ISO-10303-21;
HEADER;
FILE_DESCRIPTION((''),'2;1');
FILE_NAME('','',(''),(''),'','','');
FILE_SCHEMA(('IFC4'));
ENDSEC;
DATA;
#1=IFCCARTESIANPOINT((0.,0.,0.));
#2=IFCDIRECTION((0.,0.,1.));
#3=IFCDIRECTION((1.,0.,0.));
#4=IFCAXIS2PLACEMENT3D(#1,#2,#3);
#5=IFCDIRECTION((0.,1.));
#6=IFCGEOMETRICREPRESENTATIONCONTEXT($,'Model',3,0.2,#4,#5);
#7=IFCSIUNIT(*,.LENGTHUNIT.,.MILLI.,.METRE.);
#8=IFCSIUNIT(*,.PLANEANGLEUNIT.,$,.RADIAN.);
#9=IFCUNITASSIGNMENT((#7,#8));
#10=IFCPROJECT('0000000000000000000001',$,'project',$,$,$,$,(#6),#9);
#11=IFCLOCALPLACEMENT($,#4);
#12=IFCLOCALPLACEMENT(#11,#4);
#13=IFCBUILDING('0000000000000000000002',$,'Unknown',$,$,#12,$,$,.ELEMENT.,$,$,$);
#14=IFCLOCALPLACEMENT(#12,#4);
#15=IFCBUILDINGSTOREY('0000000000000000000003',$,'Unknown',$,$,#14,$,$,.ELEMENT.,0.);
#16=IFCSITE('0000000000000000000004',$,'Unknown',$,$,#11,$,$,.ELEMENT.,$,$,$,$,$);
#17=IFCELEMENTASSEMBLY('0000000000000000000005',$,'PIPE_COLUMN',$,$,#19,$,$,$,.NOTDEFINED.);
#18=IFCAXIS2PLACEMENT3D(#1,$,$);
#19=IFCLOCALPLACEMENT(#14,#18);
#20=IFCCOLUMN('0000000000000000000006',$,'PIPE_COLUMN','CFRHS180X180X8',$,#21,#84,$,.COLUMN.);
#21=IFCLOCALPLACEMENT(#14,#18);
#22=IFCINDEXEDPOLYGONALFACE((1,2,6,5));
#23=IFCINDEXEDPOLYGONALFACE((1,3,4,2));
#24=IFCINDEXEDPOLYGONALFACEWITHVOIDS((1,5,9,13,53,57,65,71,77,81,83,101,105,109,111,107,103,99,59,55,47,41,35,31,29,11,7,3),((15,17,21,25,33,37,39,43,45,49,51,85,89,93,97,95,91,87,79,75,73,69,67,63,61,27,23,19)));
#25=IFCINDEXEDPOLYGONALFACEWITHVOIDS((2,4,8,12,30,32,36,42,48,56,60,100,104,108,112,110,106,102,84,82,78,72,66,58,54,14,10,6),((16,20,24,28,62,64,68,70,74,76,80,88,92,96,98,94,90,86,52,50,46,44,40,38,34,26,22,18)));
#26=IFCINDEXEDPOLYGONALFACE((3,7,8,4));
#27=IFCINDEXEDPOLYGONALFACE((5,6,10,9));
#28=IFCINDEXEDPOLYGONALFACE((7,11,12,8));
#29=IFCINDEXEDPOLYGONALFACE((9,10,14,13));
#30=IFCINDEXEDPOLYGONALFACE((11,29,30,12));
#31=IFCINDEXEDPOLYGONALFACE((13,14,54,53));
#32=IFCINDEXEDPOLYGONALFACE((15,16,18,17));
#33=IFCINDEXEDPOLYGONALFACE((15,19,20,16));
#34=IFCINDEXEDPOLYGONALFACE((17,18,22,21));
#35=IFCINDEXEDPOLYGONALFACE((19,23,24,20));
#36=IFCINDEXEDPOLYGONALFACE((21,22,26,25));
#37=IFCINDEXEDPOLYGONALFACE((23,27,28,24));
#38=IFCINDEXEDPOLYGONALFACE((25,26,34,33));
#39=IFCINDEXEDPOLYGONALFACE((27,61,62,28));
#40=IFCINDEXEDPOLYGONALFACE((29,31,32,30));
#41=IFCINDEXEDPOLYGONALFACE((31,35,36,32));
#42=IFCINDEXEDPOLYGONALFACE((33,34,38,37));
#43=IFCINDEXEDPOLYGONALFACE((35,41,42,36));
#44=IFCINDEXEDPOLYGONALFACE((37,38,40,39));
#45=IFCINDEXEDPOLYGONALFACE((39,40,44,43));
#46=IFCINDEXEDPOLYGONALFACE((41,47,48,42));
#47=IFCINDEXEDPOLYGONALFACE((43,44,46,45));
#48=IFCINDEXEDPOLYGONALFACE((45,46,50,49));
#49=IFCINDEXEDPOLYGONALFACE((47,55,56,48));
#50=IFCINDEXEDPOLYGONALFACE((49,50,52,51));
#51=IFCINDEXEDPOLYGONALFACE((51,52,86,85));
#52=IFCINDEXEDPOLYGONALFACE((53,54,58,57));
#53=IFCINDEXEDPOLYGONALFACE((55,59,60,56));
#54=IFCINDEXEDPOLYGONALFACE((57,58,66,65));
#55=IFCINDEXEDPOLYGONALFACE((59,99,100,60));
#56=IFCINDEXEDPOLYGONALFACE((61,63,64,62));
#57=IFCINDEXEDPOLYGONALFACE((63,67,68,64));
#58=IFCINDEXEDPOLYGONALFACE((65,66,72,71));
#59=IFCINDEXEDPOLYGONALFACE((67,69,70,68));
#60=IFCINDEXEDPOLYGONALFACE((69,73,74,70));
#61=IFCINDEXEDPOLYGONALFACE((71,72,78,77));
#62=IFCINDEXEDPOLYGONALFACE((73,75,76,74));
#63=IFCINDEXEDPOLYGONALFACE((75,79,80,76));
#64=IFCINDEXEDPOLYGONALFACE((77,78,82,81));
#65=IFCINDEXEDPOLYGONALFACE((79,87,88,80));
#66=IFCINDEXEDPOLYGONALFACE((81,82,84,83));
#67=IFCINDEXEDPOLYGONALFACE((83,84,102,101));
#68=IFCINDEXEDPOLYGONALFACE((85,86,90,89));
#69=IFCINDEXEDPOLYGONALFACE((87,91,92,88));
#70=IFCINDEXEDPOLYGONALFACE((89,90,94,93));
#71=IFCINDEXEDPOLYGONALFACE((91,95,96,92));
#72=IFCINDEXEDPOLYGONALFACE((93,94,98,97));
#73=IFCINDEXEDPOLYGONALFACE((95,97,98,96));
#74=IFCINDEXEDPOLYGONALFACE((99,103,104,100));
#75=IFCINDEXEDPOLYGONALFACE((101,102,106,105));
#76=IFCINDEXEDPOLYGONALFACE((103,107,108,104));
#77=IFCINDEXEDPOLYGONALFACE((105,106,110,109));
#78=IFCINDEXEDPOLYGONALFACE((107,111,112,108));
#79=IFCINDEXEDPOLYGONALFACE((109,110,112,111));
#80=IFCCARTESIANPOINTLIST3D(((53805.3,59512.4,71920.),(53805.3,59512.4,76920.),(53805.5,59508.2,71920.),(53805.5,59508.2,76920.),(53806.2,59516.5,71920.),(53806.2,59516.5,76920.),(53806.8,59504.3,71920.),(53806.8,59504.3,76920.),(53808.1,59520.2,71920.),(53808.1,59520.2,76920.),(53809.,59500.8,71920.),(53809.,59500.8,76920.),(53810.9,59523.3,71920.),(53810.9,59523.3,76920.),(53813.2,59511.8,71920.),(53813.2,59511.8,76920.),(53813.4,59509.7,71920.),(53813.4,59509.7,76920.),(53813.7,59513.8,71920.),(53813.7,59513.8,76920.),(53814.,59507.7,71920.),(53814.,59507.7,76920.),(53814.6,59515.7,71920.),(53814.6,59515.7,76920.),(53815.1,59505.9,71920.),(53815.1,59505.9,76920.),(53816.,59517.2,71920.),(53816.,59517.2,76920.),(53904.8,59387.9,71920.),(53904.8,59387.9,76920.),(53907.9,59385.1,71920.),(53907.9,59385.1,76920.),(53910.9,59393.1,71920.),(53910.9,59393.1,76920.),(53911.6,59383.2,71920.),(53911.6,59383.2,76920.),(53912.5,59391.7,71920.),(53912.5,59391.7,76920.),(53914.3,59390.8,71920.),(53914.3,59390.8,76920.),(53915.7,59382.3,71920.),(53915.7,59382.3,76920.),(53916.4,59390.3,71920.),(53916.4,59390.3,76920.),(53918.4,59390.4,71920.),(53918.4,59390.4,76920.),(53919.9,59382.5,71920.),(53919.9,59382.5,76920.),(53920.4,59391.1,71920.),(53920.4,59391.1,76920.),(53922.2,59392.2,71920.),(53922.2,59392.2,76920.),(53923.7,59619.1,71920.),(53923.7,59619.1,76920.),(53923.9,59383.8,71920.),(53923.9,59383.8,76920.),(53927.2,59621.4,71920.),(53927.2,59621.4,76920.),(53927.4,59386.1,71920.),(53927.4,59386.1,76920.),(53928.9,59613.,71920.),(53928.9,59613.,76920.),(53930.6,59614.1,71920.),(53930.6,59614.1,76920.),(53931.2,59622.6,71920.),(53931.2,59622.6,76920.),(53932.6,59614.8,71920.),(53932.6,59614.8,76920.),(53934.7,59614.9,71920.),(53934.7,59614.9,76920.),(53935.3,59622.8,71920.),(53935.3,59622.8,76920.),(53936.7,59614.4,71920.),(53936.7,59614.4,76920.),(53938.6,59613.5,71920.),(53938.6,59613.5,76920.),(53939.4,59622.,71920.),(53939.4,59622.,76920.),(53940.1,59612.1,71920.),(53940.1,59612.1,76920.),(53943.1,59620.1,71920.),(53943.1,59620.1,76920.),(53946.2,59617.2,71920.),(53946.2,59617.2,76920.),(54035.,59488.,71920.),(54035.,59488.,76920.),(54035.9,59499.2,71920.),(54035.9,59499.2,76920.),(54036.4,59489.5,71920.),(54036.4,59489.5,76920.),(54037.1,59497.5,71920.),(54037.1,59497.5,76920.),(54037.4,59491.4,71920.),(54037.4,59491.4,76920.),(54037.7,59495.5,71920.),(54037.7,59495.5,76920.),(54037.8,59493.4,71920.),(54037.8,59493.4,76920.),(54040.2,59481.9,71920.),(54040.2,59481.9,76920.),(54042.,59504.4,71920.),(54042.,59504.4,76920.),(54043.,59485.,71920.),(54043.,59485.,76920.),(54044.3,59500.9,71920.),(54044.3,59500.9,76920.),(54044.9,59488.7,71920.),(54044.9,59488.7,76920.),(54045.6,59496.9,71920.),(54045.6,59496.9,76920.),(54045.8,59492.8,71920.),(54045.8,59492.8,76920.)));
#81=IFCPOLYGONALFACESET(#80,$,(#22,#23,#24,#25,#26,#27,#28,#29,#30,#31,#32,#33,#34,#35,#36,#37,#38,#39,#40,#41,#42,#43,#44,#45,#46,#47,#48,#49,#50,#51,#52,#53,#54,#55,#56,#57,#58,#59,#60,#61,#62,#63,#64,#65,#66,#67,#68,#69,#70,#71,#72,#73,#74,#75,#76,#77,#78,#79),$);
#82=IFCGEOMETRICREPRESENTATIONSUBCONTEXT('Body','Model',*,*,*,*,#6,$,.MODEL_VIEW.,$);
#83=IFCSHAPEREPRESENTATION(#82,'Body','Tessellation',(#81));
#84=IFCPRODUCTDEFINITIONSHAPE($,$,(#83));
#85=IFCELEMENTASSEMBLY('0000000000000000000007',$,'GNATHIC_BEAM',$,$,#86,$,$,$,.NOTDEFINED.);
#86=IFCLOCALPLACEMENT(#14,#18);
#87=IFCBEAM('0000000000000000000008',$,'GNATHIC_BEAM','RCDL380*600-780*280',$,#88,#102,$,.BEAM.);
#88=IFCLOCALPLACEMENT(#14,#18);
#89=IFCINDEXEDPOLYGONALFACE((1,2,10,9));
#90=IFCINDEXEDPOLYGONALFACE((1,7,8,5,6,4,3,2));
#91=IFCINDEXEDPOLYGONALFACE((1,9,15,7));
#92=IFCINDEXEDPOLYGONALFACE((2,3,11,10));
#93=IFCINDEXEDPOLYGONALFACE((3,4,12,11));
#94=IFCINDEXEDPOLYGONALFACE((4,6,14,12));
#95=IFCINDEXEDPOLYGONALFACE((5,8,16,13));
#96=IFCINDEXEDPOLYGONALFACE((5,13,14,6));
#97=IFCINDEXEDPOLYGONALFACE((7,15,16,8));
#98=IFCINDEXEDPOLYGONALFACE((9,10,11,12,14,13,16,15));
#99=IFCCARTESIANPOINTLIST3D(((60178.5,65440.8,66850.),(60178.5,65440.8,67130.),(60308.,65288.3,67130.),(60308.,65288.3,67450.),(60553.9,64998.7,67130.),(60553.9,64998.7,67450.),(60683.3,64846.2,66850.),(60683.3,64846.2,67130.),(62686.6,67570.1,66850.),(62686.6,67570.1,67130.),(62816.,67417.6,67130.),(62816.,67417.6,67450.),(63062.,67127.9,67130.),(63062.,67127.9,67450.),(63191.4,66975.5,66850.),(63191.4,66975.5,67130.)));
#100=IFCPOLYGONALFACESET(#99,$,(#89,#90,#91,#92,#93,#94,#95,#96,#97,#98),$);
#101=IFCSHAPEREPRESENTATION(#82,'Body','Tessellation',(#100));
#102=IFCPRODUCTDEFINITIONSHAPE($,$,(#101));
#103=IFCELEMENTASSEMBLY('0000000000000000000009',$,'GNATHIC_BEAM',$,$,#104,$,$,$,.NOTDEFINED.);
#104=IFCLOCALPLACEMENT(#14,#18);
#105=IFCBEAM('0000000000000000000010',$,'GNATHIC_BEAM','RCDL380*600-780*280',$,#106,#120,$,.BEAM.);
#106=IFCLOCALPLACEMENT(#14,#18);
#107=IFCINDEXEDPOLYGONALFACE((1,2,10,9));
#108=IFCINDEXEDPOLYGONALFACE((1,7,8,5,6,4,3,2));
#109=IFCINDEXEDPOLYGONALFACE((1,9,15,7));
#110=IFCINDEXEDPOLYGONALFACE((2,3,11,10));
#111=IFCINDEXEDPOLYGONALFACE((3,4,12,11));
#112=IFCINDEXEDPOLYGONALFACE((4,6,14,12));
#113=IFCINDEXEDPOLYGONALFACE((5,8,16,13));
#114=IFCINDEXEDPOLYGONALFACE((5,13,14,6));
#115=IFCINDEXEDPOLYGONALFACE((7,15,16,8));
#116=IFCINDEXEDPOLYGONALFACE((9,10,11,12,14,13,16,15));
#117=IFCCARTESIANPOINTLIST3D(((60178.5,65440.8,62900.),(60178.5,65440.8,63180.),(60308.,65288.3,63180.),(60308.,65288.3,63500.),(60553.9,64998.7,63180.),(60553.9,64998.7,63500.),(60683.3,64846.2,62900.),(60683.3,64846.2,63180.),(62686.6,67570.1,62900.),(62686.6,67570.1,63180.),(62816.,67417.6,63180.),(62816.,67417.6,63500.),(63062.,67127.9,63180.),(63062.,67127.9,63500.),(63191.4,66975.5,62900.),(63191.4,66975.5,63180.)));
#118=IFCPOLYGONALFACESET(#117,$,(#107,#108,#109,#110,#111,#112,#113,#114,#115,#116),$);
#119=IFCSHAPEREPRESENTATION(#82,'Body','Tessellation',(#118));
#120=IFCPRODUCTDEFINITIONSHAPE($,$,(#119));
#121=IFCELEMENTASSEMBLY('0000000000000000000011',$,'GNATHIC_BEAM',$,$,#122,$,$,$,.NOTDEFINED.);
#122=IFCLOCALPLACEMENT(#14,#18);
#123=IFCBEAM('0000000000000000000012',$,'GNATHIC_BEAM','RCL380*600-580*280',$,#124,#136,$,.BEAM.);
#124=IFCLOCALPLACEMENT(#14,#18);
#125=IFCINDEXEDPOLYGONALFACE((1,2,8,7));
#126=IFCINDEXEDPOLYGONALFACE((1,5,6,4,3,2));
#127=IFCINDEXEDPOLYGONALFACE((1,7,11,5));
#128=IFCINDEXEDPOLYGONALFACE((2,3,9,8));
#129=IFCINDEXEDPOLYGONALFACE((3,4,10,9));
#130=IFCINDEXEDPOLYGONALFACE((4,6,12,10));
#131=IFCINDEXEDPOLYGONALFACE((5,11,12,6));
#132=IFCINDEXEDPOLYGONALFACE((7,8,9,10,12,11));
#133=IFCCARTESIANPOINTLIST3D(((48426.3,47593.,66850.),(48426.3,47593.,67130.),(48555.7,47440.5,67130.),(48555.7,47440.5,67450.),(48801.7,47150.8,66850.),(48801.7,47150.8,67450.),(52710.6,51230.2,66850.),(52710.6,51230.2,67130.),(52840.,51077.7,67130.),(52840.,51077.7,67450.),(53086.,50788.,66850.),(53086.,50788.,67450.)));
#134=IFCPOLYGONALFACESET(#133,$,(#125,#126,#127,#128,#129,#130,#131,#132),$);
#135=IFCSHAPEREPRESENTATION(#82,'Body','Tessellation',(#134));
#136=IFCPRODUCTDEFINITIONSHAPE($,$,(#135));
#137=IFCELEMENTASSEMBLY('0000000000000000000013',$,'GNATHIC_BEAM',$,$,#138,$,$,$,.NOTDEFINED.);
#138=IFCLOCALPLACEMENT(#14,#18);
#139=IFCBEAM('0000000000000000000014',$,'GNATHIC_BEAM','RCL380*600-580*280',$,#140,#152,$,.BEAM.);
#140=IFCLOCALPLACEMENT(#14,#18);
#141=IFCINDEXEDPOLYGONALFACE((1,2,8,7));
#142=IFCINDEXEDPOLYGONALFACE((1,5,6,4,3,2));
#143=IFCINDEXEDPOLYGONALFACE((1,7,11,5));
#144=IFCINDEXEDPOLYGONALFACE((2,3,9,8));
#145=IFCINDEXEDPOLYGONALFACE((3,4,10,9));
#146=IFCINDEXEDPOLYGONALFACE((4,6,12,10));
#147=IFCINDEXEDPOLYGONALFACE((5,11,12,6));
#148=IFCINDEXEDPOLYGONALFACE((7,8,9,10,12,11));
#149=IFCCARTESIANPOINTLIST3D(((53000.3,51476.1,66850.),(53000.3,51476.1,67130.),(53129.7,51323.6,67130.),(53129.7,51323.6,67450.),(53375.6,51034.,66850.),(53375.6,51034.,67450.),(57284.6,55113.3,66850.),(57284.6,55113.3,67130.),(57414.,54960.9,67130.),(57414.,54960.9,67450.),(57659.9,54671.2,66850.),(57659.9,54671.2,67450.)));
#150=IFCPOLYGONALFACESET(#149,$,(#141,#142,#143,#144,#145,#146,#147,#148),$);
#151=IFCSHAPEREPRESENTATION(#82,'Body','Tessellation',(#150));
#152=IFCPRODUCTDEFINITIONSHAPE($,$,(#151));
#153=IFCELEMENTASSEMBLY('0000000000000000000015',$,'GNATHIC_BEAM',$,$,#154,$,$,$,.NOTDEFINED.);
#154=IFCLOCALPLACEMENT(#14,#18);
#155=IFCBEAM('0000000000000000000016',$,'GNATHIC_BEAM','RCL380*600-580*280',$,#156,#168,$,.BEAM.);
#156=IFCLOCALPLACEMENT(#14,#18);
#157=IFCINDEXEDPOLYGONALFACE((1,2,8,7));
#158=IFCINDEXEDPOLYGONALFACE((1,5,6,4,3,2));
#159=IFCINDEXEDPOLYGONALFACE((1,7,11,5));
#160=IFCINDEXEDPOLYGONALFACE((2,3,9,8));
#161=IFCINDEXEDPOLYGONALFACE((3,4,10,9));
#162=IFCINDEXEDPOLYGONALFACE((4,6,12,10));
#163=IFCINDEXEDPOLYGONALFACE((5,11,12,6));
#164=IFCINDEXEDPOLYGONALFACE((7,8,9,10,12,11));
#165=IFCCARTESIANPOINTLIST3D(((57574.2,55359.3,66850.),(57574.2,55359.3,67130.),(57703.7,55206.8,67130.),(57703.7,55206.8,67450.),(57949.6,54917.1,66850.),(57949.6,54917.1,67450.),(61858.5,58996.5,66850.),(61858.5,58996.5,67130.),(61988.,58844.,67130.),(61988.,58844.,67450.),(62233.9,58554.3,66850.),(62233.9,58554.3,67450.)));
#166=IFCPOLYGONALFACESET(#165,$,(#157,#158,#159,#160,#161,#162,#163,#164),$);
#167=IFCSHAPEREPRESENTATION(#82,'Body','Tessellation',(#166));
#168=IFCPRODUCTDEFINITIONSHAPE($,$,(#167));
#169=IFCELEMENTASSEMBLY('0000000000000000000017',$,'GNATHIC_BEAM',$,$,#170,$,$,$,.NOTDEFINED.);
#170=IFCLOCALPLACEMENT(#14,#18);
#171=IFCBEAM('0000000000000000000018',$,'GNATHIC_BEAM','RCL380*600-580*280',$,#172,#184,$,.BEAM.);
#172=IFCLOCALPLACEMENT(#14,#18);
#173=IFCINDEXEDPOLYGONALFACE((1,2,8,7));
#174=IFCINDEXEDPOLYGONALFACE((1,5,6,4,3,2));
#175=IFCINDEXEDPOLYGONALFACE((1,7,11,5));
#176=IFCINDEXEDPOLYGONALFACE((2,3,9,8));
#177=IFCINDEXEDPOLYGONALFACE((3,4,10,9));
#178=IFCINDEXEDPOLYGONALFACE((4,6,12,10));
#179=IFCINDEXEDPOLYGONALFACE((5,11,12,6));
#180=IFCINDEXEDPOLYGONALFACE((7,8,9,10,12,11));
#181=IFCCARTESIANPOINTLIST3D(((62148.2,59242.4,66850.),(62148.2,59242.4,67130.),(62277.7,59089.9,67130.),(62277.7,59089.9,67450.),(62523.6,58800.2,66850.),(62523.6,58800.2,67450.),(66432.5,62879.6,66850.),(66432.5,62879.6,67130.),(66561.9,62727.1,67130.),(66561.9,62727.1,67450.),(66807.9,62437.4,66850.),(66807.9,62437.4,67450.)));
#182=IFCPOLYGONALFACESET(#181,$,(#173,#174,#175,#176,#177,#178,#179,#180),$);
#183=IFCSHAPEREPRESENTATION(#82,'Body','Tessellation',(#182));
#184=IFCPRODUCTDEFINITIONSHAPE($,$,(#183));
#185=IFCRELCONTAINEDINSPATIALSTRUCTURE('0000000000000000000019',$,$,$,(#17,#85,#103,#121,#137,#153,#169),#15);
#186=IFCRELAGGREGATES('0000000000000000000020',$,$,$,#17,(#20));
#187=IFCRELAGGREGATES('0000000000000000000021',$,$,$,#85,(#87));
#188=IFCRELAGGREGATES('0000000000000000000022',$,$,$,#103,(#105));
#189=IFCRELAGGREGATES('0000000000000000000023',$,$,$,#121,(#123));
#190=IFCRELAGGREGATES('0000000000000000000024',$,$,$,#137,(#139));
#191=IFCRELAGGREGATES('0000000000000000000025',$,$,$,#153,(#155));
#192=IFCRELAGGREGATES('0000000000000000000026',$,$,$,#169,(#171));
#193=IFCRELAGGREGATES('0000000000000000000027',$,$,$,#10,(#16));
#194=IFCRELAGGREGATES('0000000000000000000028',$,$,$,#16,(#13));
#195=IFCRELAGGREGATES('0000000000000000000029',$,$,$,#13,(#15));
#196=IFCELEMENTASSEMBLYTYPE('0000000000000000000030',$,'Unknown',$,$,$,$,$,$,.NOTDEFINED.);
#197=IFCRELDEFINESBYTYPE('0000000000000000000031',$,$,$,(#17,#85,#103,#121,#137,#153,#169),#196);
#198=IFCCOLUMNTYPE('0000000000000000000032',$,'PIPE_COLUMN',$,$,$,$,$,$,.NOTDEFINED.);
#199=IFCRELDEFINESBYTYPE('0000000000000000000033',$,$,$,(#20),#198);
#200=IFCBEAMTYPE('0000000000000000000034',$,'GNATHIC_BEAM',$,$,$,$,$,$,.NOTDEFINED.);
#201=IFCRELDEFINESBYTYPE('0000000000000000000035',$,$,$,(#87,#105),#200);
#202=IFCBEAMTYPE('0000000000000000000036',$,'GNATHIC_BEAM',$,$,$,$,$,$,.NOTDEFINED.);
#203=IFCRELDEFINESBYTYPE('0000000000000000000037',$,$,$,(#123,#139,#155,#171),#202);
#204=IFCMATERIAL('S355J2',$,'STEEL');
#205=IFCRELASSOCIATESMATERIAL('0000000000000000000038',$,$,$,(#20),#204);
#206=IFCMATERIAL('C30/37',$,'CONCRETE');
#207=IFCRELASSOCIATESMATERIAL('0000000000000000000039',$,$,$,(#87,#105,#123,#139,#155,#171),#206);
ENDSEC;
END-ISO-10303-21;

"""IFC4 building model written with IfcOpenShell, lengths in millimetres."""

from ifc_helpers import new_model, si_unit, direction, frame, origin_with_axes, origin_2d_with_axis, place, context, subcontext, project, spatial, polyline, hollow_rectangle, outline, extrude, material, material_profile, profile_set, profile_usage, type_object, element, aggregate, save


model = new_model("IFC4")

# Units and contexts
model_context = context("Model", 3, precision=0.2, world=origin_with_axes(), true_north=direction((0.0, 1.0)))
body_context = subcontext(model_context, "Body", "Model", "MODEL_VIEW")
ifc_project = project(units=[si_unit("LENGTHUNIT", "METRE", prefix="MILLI"), si_unit("PLANEANGLEUNIT", "RADIAN")], contexts=[model_context])

# Site, building, storey
site_placement = place(None, origin_with_axes())
site = spatial("IfcSite", under=ifc_project, at=site_placement, Name="Unknown", CompositionType="ELEMENT")
building_placement = place(site_placement, origin_with_axes())
building = spatial("IfcBuilding", under=site, at=building_placement, Name="Unknown", CompositionType="ELEMENT")
storey_placement = place(building_placement, origin_with_axes())
storey = spatial("IfcBuildingStorey", under=building, at=storey_placement, Name="Unknown", CompositionType="ELEMENT", Elevation=0.0)

# Element assembly, column
element_assembly_type = type_object("IfcElementAssemblyType", Name="Unknown", PredefinedType="NOTDEFINED")
ifc_material_1 = material(Name="S355J2", Category="STEEL")
ifc_material_profile_1 = material_profile(ifc_material_1, hollow_rectangle(XDim=180.0, YDim=180.0, WallThickness=8.0, InnerFilletRadius=8.0, OuterFilletRadius=16.0, at=origin_2d_with_axis()), Name="CFRHS180X180X8")
ifc_profile_set_1 = profile_set([ifc_material_profile_1])
ifc_profile_usage_1 = profile_usage(ifc_profile_set_1, cardinal=7)
column_type_1 = type_object("IfcColumnType", Name="PIPE_COLUMN")
assembly_1_placement = place(storey_placement, frame((53925.5, 59502.6, 71920.0), z_axis=(-0.762329, -0.64719, 0.0), x_axis=(0.0, 0.0, 1.0)))
assembly_1 = element("IfcElementAssembly", 1, at=assembly_1_placement, inside=storey, type_object=element_assembly_type, Name="PIPE_COLUMN", PredefinedType="NOTDEFINED")
column_1_placement = place(assembly_1_placement, origin_with_axes())
column_1 = element("IfcColumn", 2, at=column_1_placement, type_object=column_type_1, material=ifc_profile_usage_1, Name="PIPE_COLUMN", Description="CFRHS180X180X8", PredefinedType="COLUMN", context=body_context, shape_type="SolidModel", body=[
    extrude(hollow_rectangle(XDim=180.0, YDim=180.0, WallThickness=8.0, InnerFilletRadius=8.0, OuterFilletRadius=16.0, at=origin_2d_with_axis()), frame((0.0, 0.0, 0.0), z_axis=(-1.0, 0.0, 0.0), x_axis=(0.0, 0.0, 1.0)), (0.0, 0.0, -1.0), 5000.0),
])
aggregate(assembly_1, [column_1])

# Element assemblies, beams
assembly_2_placement = place(storey_placement, frame((60430.9, 65143.5, 67150.0), z_axis=(0.64719, -0.762329, 0.0), x_axis=(0.762329, 0.64719, 0.0)))
assembly_2 = element("IfcElementAssembly", 3, at=assembly_2_placement, inside=storey, type_object=element_assembly_type, Name="GNATHIC_BEAM", PredefinedType="NOTDEFINED")
ifc_material_2 = material(Name="C30/37", Category="CONCRETE")
ifc_material_profile_2 = material_profile(ifc_material_2, outline(polyline([(-390.0, -300.0), (390.0, -300.0), (390.0, -20.0), (190.0, -20.0), (190.0, 300.0), (-190.0, 300.0), (-190.0, -20.0), (-390.0, -20.0), (-390.0, -300.0)])), Name="RCDL380*600-780*280")
ifc_profile_set_2 = profile_set([ifc_material_profile_2])
ifc_profile_usage_2 = profile_usage(ifc_profile_set_2, cardinal=2)
beam_type_1 = type_object("IfcBeamType", Name="GNATHIC_BEAM")
beam_1_placement = place(assembly_2_placement, origin_with_axes())
beam_1 = element("IfcBeam", 4, at=beam_1_placement, type_object=beam_type_1, material=ifc_profile_usage_2, Name="GNATHIC_BEAM", Description="RCDL380*600-780*280", PredefinedType="BEAM", context=body_context, shape_type="SolidModel", body=[
    extrude(outline(polyline([(-390.0, -300.0), (390.0, -300.0), (390.0, -20.0), (190.0, -20.0), (190.0, 300.0), (-190.0, 300.0), (-190.0, -20.0), (-390.0, -20.0), (-390.0, -300.0)])), frame((0.0, 0.0, 0.0), z_axis=(-1.0, 0.0, 0.0), x_axis=(0.0, 0.0, 1.0)), (0.0, 0.0, -1.0), 3290.0),
])
aggregate(assembly_2, [beam_1])
assembly_3_placement = place(storey_placement, frame((60430.9, 65143.5, 63200.0), z_axis=(0.64719, -0.762329, 0.0), x_axis=(0.762329, 0.64719, 0.0)))
assembly_3 = element("IfcElementAssembly", 5, at=assembly_3_placement, inside=storey, type_object=element_assembly_type, Name="GNATHIC_BEAM", PredefinedType="NOTDEFINED")
beam_2_placement = place(assembly_3_placement, origin_with_axes())
beam_2 = element("IfcBeam", 6, at=beam_2_placement, type_object=beam_type_1, material=ifc_profile_usage_2, Name="GNATHIC_BEAM", Description="RCDL380*600-780*280", PredefinedType="BEAM", context=body_context, shape_type="SolidModel", body=[
    extrude(outline(polyline([(-390.0, -300.0), (390.0, -300.0), (390.0, -20.0), (190.0, -20.0), (190.0, 300.0), (-190.0, 300.0), (-190.0, -20.0), (-390.0, -20.0), (-390.0, -300.0)])), frame((0.0, 0.0, 0.0), z_axis=(-1.0, 0.0, 0.0), x_axis=(0.0, 0.0, 1.0)), (0.0, 0.0, -1.0), 3290.0),
])
aggregate(assembly_3, [beam_2])
assembly_4_placement = place(storey_placement, frame((52963.0, 50932.9, 67150.0), z_axis=(-0.64719, 0.762329, 0.0), x_axis=(-0.762329, -0.64719, 0.0)))
assembly_4 = element("IfcElementAssembly", 7, at=assembly_4_placement, inside=storey, type_object=element_assembly_type, Name="GNATHIC_BEAM", PredefinedType="NOTDEFINED")
ifc_material_profile_3 = material_profile(ifc_material_2, outline(polyline([(-190.0, -300.0), (390.0, -300.0), (390.0, -20.0), (190.0, -20.0), (190.0, 300.0), (-190.0, 300.0), (-190.0, -300.0)])), Name="RCL380*600-580*280")
ifc_profile_set_3 = profile_set([ifc_material_profile_3])
ifc_profile_usage_3 = profile_usage(ifc_profile_set_3, cardinal=2)
beam_type_2 = type_object("IfcBeamType", Name="GNATHIC_BEAM")
beam_3_placement = place(assembly_4_placement, origin_with_axes())
beam_3 = element("IfcBeam", 8, at=beam_3_placement, type_object=beam_type_2, material=ifc_profile_usage_3, Name="GNATHIC_BEAM", Description="RCL380*600-580*280", PredefinedType="BEAM", context=body_context, shape_type="SolidModel", body=[
    extrude(outline(polyline([(-190.0, -300.0), (390.0, -300.0), (390.0, -20.0), (190.0, -20.0), (190.0, 300.0), (-190.0, 300.0), (-190.0, -300.0)])), frame((0.0, 0.0, 0.0), z_axis=(-1.0, 0.0, 0.0), x_axis=(0.0, 0.0, 1.0)), (0.0, 0.0, -1.0), 5620.0),
])
aggregate(assembly_4, [beam_3])
assembly_5_placement = place(storey_placement, frame((57537.0, 54816.0, 67150.0), z_axis=(-0.64719, 0.762329, 0.0), x_axis=(-0.762329, -0.64719, 0.0)))
assembly_5 = element("IfcElementAssembly", 9, at=assembly_5_placement, inside=storey, type_object=element_assembly_type, Name="GNATHIC_BEAM", PredefinedType="NOTDEFINED")
beam_4_placement = place(assembly_5_placement, origin_with_axes())
beam_4 = element("IfcBeam", 10, at=beam_4_placement, type_object=beam_type_2, material=ifc_profile_usage_3, Name="GNATHIC_BEAM", Description="RCL380*600-580*280", PredefinedType="BEAM", context=body_context, shape_type="SolidModel", body=[
    extrude(outline(polyline([(-190.0, -300.0), (390.0, -300.0), (390.0, -20.0), (190.0, -20.0), (190.0, 300.0), (-190.0, 300.0), (-190.0, -300.0)])), frame((0.0, 0.0, 0.0), z_axis=(-1.0, 0.0, 0.0), x_axis=(0.0, 0.0, 1.0)), (0.0, 0.0, -1.0), 5620.0),
])
aggregate(assembly_5, [beam_4])
assembly_6_placement = place(storey_placement, frame((62110.9, 58699.2, 67150.0), z_axis=(-0.64719, 0.762329, 0.0), x_axis=(-0.762329, -0.64719, 0.0)))
assembly_6 = element("IfcElementAssembly", 11, at=assembly_6_placement, inside=storey, type_object=element_assembly_type, Name="GNATHIC_BEAM", PredefinedType="NOTDEFINED")
beam_5_placement = place(assembly_6_placement, origin_with_axes())
beam_5 = element("IfcBeam", 12, at=beam_5_placement, type_object=beam_type_2, material=ifc_profile_usage_3, Name="GNATHIC_BEAM", Description="RCL380*600-580*280", PredefinedType="BEAM", context=body_context, shape_type="SolidModel", body=[
    extrude(outline(polyline([(-190.0, -300.0), (390.0, -300.0), (390.0, -20.0), (190.0, -20.0), (190.0, 300.0), (-190.0, 300.0), (-190.0, -300.0)])), frame((0.0, 0.0, 0.0), z_axis=(-1.0, 0.0, 0.0), x_axis=(0.0, 0.0, 1.0)), (0.0, 0.0, -1.0), 5620.0),
])
aggregate(assembly_6, [beam_5])
assembly_7_placement = place(storey_placement, frame((66684.9, 62582.3, 67150.0), z_axis=(-0.64719, 0.762329, 0.0), x_axis=(-0.762329, -0.64719, 0.0)))
assembly_7 = element("IfcElementAssembly", 13, at=assembly_7_placement, inside=storey, type_object=element_assembly_type, Name="GNATHIC_BEAM", PredefinedType="NOTDEFINED")
beam_6_placement = place(assembly_7_placement, origin_with_axes())
beam_6 = element("IfcBeam", 14, at=beam_6_placement, type_object=beam_type_2, material=ifc_profile_usage_3, Name="GNATHIC_BEAM", Description="RCL380*600-580*280", PredefinedType="BEAM", context=body_context, shape_type="SolidModel", body=[
    extrude(outline(polyline([(-190.0, -300.0), (390.0, -300.0), (390.0, -20.0), (190.0, -20.0), (190.0, 300.0), (-190.0, 300.0), (-190.0, -300.0)])), frame((0.0, 0.0, 0.0), z_axis=(-1.0, 0.0, 0.0), x_axis=(0.0, 0.0, 1.0)), (0.0, 0.0, -1.0), 5620.0),
])
aggregate(assembly_7, [beam_6])

save(model, "model.ifc")
